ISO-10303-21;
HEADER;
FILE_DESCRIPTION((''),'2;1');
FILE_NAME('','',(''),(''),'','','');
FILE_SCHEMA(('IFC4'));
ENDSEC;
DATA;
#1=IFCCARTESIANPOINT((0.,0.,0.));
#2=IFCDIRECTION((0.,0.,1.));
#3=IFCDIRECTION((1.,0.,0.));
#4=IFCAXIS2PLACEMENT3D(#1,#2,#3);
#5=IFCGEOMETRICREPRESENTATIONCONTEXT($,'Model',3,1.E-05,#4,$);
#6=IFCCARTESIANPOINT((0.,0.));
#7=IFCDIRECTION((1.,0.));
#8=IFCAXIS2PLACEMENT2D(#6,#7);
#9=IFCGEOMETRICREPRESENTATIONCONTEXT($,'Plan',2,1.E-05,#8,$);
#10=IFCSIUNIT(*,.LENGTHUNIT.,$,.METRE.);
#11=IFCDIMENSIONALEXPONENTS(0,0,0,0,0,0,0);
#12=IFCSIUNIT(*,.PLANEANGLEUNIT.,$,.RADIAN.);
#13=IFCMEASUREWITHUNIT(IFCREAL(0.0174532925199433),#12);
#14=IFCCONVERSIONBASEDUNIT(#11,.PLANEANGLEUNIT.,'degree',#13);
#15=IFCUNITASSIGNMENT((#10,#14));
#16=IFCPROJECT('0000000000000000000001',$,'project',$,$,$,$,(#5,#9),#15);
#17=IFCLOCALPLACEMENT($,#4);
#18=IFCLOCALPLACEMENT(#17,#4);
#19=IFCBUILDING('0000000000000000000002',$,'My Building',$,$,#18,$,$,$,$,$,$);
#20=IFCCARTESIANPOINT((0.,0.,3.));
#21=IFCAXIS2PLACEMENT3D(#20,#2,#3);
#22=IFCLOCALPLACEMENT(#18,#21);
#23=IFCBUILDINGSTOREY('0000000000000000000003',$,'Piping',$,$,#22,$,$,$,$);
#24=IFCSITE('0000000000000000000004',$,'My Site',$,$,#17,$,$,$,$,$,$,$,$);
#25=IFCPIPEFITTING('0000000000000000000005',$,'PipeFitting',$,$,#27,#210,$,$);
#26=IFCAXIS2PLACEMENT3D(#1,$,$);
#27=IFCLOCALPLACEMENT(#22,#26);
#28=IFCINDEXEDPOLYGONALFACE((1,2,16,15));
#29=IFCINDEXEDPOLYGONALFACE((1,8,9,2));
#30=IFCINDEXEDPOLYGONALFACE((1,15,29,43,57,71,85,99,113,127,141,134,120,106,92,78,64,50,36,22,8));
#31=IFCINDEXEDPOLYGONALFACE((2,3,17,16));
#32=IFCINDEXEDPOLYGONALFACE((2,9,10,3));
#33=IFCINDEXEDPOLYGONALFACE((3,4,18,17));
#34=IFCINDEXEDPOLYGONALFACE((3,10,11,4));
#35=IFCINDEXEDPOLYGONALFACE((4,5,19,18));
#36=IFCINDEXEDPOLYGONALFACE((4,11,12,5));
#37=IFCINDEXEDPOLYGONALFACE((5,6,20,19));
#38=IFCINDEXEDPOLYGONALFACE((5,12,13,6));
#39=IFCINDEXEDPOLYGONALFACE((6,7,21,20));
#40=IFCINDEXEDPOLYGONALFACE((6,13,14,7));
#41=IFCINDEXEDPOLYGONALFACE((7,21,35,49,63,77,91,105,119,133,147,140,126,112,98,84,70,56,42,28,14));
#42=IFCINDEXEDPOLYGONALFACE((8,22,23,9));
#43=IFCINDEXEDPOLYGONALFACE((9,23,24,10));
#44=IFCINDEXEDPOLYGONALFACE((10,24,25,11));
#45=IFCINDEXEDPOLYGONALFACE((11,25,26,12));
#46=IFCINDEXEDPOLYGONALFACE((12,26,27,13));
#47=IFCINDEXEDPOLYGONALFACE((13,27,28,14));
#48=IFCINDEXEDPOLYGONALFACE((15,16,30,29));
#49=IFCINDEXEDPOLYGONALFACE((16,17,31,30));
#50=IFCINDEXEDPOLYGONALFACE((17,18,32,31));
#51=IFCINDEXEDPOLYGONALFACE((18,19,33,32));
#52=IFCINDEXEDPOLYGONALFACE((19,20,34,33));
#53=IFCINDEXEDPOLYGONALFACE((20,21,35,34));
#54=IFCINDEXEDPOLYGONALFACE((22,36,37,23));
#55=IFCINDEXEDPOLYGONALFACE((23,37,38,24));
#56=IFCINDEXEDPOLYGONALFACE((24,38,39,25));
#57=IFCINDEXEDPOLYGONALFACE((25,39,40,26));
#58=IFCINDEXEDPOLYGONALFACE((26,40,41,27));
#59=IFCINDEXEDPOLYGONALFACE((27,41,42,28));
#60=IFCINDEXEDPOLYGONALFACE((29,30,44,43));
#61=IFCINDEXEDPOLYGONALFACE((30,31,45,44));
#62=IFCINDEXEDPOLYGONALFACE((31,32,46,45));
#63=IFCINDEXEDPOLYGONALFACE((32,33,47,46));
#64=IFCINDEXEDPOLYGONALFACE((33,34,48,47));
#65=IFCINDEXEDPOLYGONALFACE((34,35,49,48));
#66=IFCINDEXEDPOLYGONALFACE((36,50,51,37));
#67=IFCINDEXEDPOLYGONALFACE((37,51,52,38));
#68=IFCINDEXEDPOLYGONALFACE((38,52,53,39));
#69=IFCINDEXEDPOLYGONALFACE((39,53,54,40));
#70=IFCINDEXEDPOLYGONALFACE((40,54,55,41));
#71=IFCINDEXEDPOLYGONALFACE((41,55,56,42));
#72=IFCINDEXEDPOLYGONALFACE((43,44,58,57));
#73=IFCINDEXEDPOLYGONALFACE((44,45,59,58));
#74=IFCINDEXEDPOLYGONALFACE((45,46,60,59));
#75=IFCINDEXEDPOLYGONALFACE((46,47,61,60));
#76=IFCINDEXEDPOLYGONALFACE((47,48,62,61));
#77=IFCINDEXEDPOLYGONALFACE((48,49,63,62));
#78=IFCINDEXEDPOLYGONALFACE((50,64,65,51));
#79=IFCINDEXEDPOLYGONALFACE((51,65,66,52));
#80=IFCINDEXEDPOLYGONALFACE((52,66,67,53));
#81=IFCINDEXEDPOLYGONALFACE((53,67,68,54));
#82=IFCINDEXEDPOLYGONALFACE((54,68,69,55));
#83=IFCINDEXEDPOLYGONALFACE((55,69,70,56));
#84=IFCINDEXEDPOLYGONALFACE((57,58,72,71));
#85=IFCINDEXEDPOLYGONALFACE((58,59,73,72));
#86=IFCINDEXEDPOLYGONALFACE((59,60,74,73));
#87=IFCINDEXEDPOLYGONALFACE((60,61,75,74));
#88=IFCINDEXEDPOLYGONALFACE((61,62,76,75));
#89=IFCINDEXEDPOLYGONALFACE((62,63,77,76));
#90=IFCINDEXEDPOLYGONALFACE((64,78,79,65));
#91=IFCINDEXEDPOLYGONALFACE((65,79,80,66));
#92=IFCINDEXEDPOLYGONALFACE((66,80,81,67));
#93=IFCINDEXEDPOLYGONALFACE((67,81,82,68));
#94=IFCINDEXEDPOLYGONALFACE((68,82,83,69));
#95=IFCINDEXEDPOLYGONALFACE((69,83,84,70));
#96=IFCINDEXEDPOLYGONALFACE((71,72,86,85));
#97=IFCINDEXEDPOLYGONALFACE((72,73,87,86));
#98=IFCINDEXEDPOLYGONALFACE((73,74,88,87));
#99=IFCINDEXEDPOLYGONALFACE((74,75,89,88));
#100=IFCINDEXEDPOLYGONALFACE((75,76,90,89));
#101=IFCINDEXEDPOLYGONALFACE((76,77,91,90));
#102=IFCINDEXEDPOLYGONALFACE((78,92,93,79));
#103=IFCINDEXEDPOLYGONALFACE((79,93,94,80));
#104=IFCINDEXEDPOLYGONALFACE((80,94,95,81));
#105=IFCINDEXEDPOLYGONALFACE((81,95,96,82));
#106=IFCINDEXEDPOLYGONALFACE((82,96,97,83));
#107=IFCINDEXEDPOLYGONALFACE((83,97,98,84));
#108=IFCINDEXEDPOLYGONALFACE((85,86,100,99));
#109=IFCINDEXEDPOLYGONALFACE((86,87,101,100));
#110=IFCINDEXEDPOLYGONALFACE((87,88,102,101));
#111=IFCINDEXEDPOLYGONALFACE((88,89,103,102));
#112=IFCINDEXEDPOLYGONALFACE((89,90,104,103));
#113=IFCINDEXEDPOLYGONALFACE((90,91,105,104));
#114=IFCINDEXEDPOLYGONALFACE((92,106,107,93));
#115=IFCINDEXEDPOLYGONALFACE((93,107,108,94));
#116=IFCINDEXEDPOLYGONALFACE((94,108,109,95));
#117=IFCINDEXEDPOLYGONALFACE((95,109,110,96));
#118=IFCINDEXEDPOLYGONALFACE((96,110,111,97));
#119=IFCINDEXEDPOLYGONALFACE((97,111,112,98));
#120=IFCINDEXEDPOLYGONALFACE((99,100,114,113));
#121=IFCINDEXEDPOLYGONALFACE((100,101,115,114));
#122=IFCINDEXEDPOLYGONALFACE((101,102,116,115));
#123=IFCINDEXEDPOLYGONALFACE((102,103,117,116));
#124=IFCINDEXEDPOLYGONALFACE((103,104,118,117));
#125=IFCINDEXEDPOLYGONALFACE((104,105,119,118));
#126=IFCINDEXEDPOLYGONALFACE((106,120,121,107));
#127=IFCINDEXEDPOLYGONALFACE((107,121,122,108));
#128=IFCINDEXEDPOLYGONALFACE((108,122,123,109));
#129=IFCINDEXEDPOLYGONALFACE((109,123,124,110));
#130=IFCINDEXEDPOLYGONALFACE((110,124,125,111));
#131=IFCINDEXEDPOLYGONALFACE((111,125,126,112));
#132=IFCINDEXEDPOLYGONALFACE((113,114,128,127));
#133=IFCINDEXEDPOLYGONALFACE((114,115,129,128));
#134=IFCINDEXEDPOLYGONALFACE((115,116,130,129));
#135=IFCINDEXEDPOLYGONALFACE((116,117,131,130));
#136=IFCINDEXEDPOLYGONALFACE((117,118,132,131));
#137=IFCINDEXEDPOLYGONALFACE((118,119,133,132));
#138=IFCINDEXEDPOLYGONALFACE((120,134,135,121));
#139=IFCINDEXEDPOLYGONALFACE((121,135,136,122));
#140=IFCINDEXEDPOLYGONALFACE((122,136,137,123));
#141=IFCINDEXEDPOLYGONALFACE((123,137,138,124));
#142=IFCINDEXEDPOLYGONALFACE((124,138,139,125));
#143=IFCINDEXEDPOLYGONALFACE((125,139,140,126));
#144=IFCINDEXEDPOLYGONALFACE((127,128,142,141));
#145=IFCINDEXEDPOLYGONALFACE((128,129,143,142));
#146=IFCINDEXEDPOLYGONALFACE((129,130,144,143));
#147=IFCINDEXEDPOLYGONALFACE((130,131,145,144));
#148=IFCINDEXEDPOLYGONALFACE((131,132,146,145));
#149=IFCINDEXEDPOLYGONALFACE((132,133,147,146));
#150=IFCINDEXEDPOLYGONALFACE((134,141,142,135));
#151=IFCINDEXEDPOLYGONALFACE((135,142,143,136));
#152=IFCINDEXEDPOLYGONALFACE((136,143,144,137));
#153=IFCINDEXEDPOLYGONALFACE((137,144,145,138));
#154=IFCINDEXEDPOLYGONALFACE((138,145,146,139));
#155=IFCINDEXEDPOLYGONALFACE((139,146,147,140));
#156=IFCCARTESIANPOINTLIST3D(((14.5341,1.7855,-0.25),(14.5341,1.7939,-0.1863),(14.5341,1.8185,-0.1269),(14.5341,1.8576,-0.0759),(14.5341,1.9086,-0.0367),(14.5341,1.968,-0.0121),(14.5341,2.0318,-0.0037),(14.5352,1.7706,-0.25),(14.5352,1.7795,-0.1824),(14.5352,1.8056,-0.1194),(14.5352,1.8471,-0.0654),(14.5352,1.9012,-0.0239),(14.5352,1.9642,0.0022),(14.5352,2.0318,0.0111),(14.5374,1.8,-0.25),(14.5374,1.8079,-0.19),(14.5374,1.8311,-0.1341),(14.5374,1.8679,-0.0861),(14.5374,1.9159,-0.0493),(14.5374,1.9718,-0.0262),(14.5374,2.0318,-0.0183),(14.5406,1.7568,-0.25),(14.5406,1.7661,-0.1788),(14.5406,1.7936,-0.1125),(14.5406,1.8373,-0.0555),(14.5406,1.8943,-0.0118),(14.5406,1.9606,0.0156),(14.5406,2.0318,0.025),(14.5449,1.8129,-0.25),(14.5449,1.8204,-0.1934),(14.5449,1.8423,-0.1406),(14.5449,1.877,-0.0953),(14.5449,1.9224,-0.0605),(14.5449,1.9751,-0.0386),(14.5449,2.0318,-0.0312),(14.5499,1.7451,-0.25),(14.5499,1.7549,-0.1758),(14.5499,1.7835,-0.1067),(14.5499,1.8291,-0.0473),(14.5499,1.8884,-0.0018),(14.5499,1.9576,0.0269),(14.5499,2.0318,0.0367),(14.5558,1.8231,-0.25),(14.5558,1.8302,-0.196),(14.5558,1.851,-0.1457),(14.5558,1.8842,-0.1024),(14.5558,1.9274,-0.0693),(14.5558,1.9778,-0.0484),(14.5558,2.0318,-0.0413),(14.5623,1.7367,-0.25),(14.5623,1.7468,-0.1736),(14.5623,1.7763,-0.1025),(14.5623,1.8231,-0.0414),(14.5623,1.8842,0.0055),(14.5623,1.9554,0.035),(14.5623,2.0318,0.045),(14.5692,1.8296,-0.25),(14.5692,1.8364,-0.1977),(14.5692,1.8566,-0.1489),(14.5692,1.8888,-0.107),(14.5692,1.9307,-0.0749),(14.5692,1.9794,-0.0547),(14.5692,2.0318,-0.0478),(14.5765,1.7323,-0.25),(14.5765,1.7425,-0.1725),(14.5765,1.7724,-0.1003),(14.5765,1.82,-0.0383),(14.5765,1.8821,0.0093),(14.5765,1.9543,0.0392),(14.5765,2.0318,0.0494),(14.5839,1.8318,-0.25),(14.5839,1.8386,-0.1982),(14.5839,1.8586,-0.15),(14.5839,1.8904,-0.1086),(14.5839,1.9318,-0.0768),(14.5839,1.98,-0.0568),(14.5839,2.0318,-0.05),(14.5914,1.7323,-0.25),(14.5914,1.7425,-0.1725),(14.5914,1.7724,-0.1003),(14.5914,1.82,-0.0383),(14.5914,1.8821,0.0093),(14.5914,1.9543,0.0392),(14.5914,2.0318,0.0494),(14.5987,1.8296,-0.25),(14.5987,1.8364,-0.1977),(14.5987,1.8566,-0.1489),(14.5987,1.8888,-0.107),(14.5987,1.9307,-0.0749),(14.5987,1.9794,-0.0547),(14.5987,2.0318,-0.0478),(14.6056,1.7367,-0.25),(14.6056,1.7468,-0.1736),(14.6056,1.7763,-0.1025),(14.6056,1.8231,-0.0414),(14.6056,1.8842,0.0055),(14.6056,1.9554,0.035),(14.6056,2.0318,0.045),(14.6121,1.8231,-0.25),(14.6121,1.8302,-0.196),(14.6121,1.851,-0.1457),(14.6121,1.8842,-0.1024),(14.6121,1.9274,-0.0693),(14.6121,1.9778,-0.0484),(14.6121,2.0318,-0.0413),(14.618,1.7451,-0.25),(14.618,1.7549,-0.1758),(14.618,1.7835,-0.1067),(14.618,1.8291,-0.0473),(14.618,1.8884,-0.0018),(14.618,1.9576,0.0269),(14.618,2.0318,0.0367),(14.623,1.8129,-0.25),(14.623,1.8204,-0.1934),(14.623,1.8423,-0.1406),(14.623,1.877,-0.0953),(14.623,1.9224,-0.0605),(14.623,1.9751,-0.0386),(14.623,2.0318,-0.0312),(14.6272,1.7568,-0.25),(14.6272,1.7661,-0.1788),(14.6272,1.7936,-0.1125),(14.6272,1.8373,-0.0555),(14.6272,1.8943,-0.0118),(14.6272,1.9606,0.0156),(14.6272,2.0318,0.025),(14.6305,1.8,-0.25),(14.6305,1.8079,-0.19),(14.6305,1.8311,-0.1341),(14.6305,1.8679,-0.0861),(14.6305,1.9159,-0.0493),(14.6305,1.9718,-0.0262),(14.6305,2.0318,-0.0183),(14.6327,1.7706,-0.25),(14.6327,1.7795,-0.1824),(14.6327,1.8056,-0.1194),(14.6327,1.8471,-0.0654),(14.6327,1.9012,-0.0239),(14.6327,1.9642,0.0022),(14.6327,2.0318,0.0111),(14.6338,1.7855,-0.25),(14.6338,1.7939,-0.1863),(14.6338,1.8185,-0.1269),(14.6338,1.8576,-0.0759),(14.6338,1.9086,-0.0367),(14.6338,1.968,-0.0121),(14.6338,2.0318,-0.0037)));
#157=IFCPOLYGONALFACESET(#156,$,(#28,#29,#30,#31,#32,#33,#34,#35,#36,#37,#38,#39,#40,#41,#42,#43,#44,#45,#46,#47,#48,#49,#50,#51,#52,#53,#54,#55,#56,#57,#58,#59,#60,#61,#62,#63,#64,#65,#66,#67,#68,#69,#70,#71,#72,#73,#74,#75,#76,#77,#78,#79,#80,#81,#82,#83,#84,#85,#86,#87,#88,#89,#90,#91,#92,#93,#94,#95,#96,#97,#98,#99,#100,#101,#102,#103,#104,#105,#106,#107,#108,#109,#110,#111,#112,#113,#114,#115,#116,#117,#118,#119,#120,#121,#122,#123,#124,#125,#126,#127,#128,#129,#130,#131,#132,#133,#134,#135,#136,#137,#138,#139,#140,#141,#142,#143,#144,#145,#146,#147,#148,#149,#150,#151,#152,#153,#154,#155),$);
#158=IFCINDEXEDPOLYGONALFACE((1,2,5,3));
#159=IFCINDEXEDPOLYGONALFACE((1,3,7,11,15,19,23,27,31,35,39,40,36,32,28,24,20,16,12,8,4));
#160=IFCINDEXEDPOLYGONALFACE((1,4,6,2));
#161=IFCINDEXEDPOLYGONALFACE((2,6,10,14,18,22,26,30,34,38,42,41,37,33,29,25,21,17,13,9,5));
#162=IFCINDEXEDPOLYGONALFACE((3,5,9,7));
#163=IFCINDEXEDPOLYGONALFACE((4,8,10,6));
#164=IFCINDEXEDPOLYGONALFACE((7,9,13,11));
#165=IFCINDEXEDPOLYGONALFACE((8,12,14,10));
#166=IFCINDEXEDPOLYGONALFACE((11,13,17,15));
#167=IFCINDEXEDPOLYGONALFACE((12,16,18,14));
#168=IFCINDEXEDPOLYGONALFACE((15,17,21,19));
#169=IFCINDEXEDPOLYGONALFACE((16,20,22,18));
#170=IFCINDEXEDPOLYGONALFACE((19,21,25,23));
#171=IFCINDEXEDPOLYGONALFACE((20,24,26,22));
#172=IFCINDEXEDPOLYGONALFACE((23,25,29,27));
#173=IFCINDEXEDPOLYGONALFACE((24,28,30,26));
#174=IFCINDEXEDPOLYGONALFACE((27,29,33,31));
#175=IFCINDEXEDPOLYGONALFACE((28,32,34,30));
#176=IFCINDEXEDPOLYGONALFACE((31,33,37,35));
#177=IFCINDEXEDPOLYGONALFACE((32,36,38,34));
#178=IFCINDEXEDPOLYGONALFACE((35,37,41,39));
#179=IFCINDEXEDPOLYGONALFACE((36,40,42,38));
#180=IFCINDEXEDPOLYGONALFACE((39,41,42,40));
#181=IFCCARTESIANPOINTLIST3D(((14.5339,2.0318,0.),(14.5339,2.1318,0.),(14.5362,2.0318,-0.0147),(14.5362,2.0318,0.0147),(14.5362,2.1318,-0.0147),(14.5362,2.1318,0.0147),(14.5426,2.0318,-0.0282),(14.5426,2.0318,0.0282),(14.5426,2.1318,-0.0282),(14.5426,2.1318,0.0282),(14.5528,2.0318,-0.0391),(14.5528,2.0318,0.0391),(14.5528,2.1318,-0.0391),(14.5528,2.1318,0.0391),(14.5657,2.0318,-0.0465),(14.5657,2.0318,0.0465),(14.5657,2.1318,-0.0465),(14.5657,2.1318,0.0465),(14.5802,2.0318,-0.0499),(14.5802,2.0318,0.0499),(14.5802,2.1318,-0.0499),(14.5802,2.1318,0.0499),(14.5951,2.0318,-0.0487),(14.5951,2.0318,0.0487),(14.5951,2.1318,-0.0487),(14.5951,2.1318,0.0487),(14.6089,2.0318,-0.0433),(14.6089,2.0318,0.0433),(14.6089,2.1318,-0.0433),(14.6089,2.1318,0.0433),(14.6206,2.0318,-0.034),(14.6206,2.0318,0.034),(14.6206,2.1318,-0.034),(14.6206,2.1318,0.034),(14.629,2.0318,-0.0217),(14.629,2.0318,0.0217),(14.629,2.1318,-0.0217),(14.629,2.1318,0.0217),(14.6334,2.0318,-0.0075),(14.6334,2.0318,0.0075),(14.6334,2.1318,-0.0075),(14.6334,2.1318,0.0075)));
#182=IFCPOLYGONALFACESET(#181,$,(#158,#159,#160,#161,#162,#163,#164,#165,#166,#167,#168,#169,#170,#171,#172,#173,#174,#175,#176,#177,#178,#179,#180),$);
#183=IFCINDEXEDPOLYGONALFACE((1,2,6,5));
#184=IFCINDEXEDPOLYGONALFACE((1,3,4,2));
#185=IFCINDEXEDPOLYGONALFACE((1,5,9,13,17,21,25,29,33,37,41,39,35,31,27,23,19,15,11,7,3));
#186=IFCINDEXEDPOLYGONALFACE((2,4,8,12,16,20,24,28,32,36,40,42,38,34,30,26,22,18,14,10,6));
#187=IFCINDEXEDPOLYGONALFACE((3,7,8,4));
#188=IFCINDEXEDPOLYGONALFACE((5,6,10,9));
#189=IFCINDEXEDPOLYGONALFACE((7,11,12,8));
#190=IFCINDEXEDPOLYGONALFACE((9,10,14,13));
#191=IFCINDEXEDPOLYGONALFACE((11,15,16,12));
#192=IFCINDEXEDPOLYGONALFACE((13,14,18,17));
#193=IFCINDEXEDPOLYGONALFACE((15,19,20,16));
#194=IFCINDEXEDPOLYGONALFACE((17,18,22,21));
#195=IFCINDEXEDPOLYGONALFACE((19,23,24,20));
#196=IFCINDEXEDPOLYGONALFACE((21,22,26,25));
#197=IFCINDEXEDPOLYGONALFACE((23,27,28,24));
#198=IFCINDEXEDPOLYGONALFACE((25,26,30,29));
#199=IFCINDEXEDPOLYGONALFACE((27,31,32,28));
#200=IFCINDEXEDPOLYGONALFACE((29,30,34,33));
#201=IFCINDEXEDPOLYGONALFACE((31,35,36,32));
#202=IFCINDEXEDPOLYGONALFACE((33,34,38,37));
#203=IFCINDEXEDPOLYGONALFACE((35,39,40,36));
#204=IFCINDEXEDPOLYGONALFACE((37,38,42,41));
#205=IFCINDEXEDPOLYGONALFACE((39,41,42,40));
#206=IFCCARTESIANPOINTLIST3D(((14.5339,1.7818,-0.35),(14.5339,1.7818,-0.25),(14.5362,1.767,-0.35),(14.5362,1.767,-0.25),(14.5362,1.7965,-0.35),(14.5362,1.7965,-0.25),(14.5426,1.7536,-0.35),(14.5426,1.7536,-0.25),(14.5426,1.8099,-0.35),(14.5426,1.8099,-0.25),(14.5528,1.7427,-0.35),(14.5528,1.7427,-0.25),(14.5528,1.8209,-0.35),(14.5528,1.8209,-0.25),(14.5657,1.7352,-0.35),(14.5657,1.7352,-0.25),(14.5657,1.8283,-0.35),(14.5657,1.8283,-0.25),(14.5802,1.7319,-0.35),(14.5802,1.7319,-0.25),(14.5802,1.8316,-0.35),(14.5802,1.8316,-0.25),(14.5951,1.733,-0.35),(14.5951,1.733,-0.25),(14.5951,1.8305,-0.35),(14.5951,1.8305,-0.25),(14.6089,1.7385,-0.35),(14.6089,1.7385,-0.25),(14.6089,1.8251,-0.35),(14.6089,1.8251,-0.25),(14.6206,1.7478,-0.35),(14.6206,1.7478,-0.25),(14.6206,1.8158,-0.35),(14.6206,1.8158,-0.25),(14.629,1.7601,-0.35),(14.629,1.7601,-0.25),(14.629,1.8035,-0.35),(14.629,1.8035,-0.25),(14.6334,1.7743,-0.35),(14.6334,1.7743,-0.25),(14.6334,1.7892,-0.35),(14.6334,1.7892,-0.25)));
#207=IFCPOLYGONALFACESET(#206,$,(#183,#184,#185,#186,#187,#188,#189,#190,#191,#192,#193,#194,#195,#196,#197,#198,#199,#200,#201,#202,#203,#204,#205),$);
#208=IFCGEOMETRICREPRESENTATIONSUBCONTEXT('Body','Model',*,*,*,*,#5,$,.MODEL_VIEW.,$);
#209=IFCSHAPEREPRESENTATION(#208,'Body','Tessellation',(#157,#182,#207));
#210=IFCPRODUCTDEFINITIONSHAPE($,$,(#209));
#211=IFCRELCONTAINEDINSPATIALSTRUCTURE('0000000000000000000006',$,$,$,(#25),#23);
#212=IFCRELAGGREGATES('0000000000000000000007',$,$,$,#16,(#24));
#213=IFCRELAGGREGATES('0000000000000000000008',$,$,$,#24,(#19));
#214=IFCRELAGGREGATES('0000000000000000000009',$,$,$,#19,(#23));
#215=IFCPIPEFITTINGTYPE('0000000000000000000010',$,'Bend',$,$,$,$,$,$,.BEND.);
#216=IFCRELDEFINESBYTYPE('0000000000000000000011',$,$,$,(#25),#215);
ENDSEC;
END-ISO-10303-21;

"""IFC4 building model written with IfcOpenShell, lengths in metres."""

from ifc_helpers import new_model, entity, si_unit, converted_unit, frame, origin_with_axes, origin_2d_with_axis, place, context, subcontext, project, spatial, circle, extrude, source, transform, mapped, type_object, type_shapes, element, save


model = new_model("IFC4")

# Units and contexts
model_context = context("Model", 3, precision=1e-05, world=origin_with_axes())
plan_context = context("Plan", 2, precision=1e-05, world=origin_2d_with_axis())
body_context = subcontext(model_context, "Body", "Model", "MODEL_VIEW")
ifc_project = project(units=[si_unit("LENGTHUNIT", "METRE"), converted_unit("PLANEANGLEUNIT", "degree", entity("IfcReal", 0.0174532925199433), si_unit("PLANEANGLEUNIT", "RADIAN"), dimensions=[0, 0, 0, 0, 0, 0, 0])], contexts=[model_context, plan_context])

# Site, building, storey
site_placement = place(None, origin_with_axes())
site = spatial("IfcSite", under=ifc_project, at=site_placement, Name="My Site")
building_placement = place(site_placement, origin_with_axes())
building = spatial("IfcBuilding", under=site, at=building_placement, Name="My Building")
storey_placement = place(building_placement, frame((0.0, 0.0, 3.0), z_axis=(0.0, 0.0, 1.0), x_axis=(1.0, 0.0, 0.0)))
storey = spatial("IfcBuildingStorey", under=building, at=storey_placement, Name="Piping")

# Pipe fitting
pipe_fitting_type = type_object("IfcPipeFittingType", Name="Bend", PredefinedType="BEND")
shared_shape = source(origin_with_axes(), body_context, "Body", "SolidModel", [
    entity("IfcSweptDiskSolid", entity("IfcIndexedPolyCurve", entity("IfcCartesianPointList3D", [[0.0, 0.0, -0.1], [0.0, -0.0732, -0.2768], [0.0, -0.25, -0.35]]), [entity("IfcArcIndex", [1, 2, 3])]), 0.05),
    extrude(circle(Radius=0.05), origin_with_axes(), (0.0, 0.0, -1.0), 0.1),
    extrude(circle(Radius=0.05), frame((0.0, -0.25, -0.35), z_axis=(0.0, -1.0, 0.0), x_axis=(1.0, 0.0, 0.0)), (0.0, 0.0, 1.0), 0.1),
])
type_shapes(pipe_fitting_type, [shared_shape])
for number, where, z_axis, x_axis, name in (
    (1, (14.5839, 2.1318, 0.0), (0.0, 1.0, 0.0), (-1.0, 0.0, 0.0), "PipeFitting"),
):
    element("IfcPipeFitting", number, at=place(storey_placement, frame(where, z_axis=z_axis, x_axis=x_axis)), inside=storey, type_object=pipe_fitting_type, Name=name, context=body_context, shape_type="MappedRepresentation", body=[
        mapped(shared_shape, transform((0.0, 0.0, 0.0), x_axis=(1.0, 0.0, 0.0), y_axis=(0.0, 1.0, 0.0), z_axis=(0.0, 0.0, 1.0), scale=1.0)),
    ])

save(model, "model.ifc")
